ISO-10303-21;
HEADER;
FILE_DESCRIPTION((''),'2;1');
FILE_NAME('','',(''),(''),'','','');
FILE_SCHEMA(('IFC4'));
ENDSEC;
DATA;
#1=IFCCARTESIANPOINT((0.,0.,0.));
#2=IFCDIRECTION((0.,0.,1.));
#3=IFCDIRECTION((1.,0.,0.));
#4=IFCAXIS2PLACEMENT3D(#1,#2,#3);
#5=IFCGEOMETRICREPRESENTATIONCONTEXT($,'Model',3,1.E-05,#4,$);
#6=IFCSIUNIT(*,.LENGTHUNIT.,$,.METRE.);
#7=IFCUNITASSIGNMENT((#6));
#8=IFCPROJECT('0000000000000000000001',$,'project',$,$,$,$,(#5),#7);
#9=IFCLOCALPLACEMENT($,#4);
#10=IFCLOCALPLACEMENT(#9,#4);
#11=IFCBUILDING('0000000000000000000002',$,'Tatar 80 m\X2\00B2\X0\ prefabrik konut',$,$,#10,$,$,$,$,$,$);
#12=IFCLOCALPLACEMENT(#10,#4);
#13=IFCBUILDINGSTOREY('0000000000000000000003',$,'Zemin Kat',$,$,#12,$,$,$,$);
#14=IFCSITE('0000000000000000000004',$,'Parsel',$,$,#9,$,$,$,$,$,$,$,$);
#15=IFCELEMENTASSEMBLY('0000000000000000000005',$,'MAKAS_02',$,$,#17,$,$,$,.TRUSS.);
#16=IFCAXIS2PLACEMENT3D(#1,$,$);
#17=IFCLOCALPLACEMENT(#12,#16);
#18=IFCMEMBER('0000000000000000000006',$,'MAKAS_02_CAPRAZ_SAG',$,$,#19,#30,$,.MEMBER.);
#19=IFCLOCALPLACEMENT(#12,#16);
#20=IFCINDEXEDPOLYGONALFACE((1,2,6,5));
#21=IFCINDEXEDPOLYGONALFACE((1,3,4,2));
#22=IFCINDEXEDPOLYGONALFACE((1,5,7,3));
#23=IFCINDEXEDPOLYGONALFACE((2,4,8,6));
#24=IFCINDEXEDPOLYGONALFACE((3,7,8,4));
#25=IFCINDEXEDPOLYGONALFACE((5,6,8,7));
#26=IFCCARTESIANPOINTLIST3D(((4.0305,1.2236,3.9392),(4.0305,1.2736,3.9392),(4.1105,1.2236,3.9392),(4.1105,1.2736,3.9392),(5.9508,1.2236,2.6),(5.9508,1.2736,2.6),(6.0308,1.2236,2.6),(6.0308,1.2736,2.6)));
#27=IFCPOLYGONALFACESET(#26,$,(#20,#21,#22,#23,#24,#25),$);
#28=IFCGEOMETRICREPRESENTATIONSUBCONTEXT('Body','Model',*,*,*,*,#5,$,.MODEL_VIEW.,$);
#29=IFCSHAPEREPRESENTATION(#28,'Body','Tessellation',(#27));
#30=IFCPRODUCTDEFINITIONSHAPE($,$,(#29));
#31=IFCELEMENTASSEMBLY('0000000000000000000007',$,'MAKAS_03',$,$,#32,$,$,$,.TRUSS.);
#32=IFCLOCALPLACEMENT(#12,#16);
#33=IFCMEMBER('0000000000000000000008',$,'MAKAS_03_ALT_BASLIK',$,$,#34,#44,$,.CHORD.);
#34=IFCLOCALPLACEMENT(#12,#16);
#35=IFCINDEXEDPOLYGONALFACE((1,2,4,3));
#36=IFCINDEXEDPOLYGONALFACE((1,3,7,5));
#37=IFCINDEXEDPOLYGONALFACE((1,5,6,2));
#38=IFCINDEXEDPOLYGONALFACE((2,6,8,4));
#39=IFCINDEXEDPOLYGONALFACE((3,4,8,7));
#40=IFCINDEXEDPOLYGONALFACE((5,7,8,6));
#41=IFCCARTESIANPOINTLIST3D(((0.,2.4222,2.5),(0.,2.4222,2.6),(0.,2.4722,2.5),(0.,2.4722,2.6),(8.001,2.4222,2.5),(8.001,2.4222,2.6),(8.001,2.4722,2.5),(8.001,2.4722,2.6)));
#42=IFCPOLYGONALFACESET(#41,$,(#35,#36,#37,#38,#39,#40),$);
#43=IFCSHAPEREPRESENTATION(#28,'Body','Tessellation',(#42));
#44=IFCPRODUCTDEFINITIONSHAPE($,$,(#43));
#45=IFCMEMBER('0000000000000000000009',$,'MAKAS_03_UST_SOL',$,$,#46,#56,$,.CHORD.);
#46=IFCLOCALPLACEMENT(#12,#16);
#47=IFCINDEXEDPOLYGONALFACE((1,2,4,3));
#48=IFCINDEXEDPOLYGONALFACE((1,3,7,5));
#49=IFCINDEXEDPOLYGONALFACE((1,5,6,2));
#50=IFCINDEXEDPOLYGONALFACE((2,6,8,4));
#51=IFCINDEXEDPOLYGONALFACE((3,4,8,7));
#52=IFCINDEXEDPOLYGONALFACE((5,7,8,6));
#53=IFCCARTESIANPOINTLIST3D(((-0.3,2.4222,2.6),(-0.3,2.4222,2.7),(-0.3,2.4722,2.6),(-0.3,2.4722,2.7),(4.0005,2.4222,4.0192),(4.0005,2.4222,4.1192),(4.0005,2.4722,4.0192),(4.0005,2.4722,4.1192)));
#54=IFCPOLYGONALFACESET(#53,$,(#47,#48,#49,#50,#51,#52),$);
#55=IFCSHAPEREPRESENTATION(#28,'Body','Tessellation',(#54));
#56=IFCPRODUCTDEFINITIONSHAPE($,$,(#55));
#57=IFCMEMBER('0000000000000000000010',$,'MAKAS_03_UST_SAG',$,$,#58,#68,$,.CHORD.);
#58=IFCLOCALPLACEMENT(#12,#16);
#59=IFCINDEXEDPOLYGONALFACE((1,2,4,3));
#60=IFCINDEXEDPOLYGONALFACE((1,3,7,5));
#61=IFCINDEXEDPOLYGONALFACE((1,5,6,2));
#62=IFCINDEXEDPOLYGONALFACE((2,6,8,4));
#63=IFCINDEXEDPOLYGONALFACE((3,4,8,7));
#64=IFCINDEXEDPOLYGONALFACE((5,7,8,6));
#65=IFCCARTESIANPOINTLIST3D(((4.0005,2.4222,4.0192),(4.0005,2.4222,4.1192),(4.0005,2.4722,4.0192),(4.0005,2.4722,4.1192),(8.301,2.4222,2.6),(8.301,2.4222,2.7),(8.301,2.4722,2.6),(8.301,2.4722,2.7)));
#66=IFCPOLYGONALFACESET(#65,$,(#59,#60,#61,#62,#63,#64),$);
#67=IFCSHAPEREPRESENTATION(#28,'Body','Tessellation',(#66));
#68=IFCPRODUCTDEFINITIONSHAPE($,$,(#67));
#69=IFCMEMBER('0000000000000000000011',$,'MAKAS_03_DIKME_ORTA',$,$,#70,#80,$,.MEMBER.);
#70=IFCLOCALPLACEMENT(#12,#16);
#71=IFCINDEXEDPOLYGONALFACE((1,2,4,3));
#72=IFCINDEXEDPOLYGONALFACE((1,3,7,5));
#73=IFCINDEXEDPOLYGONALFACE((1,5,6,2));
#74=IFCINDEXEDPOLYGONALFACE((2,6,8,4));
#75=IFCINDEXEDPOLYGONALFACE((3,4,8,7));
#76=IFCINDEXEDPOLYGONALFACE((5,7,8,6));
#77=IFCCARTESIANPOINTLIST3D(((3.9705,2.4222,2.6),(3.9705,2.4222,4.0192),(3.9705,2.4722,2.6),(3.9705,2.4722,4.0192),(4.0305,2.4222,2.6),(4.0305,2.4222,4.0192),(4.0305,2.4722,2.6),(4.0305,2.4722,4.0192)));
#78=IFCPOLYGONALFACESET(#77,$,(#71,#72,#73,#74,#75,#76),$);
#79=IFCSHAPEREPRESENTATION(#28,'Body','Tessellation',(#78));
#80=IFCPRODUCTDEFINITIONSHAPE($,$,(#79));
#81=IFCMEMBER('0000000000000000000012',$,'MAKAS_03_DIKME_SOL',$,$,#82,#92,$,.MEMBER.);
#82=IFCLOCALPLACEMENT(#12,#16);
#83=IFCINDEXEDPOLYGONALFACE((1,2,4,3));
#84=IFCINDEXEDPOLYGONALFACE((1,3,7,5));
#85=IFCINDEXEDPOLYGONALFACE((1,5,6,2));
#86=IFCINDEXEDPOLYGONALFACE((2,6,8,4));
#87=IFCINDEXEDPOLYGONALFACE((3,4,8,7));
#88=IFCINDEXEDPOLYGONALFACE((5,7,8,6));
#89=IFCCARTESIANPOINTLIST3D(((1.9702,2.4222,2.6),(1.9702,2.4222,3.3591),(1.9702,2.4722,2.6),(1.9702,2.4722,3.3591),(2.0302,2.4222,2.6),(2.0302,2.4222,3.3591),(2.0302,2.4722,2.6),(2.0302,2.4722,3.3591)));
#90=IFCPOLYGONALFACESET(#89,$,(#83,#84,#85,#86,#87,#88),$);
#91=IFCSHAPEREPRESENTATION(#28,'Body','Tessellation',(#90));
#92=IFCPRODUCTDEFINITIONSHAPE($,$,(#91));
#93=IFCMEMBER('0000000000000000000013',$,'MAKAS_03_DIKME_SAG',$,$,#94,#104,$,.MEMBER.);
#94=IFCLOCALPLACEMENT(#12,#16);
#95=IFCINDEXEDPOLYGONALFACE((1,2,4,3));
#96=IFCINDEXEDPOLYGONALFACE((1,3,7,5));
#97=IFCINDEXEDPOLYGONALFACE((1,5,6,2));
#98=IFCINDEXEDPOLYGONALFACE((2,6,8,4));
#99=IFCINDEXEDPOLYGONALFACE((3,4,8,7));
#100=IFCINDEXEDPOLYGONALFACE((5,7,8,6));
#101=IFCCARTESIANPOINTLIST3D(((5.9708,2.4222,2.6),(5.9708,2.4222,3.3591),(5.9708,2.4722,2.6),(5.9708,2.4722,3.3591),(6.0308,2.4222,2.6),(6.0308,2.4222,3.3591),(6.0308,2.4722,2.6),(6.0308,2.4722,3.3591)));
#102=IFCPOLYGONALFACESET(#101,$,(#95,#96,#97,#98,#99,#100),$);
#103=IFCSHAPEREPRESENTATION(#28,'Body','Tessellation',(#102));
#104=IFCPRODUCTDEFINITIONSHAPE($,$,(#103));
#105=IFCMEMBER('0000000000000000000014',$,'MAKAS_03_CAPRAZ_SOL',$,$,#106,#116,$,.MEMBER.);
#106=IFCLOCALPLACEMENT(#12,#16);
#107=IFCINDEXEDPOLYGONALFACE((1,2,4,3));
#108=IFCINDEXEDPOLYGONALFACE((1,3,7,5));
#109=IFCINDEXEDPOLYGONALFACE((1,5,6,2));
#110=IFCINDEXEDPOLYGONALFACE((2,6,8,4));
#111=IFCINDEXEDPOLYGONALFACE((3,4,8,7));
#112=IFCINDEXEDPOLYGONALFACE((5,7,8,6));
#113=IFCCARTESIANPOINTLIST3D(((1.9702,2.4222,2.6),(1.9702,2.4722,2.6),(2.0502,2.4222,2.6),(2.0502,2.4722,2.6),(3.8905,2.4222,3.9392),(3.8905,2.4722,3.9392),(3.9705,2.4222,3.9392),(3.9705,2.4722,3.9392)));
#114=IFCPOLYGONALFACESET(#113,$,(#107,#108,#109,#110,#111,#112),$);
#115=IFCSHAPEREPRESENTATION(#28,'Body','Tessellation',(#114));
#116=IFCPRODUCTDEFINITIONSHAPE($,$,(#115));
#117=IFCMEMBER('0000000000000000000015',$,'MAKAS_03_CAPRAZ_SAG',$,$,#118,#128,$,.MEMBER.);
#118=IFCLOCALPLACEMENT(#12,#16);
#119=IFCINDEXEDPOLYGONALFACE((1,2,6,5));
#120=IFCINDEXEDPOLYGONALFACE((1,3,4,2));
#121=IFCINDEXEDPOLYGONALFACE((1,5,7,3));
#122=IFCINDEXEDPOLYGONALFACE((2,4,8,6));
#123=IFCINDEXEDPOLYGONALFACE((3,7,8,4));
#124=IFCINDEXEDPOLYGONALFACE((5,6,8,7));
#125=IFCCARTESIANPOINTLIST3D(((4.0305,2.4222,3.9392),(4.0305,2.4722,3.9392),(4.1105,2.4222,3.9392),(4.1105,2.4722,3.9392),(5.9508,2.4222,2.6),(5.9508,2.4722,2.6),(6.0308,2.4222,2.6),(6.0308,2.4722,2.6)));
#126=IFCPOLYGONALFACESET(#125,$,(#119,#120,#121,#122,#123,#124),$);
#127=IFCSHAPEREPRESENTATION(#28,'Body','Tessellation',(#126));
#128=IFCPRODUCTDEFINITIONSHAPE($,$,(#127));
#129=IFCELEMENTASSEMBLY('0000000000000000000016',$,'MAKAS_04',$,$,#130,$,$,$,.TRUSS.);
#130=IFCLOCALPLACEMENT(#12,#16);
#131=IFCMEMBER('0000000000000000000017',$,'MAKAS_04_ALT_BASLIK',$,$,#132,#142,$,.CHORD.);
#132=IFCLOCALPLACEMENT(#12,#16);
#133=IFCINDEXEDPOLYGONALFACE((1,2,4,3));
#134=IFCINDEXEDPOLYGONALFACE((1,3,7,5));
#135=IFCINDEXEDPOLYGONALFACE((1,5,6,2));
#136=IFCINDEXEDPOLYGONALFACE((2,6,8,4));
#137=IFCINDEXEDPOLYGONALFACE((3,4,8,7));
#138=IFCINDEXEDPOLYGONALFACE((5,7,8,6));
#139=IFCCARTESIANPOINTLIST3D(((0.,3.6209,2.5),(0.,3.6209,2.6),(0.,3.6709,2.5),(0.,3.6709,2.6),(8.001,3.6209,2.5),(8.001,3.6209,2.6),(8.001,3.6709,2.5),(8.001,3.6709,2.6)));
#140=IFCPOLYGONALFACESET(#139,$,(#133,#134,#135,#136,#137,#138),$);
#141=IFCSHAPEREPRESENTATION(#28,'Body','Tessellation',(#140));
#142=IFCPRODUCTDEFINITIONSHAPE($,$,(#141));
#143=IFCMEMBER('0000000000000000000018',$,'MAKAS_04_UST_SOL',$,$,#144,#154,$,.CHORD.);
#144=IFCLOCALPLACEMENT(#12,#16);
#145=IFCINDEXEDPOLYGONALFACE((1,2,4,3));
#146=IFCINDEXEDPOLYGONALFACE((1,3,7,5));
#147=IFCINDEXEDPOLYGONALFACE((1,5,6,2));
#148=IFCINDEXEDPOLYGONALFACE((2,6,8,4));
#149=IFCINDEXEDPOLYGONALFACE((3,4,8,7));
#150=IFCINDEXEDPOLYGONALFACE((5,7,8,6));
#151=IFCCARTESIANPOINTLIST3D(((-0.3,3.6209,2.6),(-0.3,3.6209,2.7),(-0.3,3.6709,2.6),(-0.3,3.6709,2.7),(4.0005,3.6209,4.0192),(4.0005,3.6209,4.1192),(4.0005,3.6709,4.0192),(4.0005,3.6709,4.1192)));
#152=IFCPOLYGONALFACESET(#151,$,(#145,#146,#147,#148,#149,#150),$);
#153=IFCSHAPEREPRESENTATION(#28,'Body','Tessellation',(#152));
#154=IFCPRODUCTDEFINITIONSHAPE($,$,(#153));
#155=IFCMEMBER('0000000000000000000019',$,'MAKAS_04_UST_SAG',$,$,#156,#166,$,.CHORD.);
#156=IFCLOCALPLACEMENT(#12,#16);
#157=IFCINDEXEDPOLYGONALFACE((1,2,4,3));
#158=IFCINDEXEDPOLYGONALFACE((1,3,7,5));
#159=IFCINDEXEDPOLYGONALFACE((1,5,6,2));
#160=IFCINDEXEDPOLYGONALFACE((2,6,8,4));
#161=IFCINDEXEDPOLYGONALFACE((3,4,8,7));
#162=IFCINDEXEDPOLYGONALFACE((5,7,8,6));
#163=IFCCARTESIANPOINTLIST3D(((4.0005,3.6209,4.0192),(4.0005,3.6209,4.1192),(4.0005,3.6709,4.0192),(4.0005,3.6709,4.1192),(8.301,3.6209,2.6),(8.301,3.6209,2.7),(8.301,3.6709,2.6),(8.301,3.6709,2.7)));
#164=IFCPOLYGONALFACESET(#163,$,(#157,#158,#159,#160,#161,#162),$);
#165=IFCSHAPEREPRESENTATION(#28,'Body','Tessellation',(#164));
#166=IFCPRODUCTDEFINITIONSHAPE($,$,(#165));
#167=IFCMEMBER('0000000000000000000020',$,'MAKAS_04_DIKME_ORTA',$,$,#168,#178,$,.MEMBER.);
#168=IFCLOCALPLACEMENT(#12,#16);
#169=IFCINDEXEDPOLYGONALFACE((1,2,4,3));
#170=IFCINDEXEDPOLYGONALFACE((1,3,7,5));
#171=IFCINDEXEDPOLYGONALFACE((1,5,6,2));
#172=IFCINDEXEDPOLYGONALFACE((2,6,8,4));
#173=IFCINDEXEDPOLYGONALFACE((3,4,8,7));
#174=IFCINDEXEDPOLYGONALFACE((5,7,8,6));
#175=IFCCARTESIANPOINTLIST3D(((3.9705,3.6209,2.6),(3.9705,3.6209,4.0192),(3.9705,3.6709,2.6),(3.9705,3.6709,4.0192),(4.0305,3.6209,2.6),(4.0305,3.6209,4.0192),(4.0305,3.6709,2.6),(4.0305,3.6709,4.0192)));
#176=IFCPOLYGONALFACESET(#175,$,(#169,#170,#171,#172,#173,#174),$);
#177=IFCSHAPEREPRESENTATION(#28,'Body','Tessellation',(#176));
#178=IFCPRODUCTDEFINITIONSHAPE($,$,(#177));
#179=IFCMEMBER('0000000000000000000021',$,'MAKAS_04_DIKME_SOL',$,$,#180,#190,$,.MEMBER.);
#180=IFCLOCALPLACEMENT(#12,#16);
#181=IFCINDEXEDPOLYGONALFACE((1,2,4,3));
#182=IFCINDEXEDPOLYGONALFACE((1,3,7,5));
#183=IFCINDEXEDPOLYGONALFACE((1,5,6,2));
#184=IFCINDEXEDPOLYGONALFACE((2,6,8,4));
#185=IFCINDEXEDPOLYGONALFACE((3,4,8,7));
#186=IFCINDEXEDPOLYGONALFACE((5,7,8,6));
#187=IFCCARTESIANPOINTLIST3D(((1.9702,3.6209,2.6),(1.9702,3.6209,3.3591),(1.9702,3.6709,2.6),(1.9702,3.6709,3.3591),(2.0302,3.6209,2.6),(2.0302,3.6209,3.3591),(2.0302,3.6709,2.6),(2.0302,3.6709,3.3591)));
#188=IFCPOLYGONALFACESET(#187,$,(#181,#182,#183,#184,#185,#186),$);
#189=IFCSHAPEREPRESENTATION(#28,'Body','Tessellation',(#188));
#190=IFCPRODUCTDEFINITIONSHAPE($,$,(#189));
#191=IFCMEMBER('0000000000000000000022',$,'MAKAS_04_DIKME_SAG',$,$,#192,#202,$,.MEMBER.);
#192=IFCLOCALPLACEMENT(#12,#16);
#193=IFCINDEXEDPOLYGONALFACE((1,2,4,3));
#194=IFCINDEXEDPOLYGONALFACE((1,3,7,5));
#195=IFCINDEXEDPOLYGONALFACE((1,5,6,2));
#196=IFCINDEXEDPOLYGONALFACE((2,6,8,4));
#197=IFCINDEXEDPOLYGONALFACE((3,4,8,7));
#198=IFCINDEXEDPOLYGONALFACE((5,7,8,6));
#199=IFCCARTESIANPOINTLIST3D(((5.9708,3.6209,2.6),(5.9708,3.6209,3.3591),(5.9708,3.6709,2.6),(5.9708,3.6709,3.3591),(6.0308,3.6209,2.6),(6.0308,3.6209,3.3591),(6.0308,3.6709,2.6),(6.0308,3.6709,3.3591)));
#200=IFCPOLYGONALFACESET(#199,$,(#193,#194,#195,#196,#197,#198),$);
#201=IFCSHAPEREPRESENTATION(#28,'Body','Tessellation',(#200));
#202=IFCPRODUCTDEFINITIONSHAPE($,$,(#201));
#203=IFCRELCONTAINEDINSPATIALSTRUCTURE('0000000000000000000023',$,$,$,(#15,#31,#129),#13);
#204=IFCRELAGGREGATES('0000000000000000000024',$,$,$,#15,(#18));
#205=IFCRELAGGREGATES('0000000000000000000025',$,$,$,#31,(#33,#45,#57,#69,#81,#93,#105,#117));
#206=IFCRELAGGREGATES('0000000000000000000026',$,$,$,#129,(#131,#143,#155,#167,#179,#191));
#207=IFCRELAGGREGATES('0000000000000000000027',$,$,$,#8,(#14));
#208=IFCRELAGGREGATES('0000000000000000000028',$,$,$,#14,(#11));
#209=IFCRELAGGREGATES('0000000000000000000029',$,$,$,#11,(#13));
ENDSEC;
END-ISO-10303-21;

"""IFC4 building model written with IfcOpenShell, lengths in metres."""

from ifc_helpers import new_model, si_unit, frame, origin_with_axes, place, context, subcontext, project, spatial, line, indexed_curve, outline, extrude, element, aggregate, save


model = new_model("IFC4")

# Units and contexts
model_context = context("Model", 3, precision=1e-05, world=origin_with_axes())
body_context = subcontext(model_context, "Body", "Model", "MODEL_VIEW")
ifc_project = project(units=[si_unit("LENGTHUNIT", "METRE")], contexts=[model_context])

# Site, building, storey
site_placement = place(None, origin_with_axes())
site = spatial("IfcSite", under=ifc_project, at=site_placement, Name="Parsel")
building_placement = place(site_placement, origin_with_axes())
building = spatial("IfcBuilding", under=site, at=building_placement, Name="Tatar 80 m² prefabrik konut")
storey_placement = place(building_placement, origin_with_axes())
storey = spatial("IfcBuildingStorey", under=building, at=storey_placement, Name="Zemin Kat")

# Element assemblies, members
assembly_1_placement = place(storey_placement, origin_with_axes())
assembly_1 = element("IfcElementAssembly", 1, at=assembly_1_placement, inside=storey, Name="MAKAS_02", PredefinedType="TRUSS")
member_1_placement = place(assembly_1_placement, origin_with_axes())
member_1 = element("IfcMember", 2, at=member_1_placement, Name="MAKAS_02_CAPRAZ_SAG", PredefinedType="MEMBER", context=body_context, shape_type="SweptSolid", body=[
    extrude(outline(indexed_curve([(5.9508, 2.6), (6.0308, 2.6), (4.1105, 3.9392), (4.0305, 3.9392)], segments=[line(1, 2, 3, 4, 1)])), frame((0.0, 1.2736, 0.0), z_axis=(0.0, -1.0, 0.0), x_axis=(1.0, 0.0, 0.0)), (0.0, 0.0, 1.0), 0.05),
])
aggregate(assembly_1, [member_1])
assembly_2_placement = place(storey_placement, origin_with_axes())
assembly_2 = element("IfcElementAssembly", 3, at=assembly_2_placement, inside=storey, Name="MAKAS_03", PredefinedType="TRUSS")
member_2_placement = place(assembly_2_placement, origin_with_axes())
member_2 = element("IfcMember", 4, at=member_2_placement, Name="MAKAS_03_ALT_BASLIK", PredefinedType="CHORD", context=body_context, shape_type="SweptSolid", body=[
    extrude(outline(indexed_curve([(0.0, 2.5), (8.001, 2.5), (8.001, 2.6), (0.0, 2.6)], segments=[line(1, 2, 3, 4, 1)])), frame((0.0, 2.4722, 0.0), z_axis=(0.0, -1.0, 0.0), x_axis=(1.0, 0.0, 0.0)), (0.0, 0.0, 1.0), 0.05),
])
member_3_placement = place(assembly_2_placement, origin_with_axes())
member_3 = element("IfcMember", 5, at=member_3_placement, Name="MAKAS_03_UST_SOL", PredefinedType="CHORD", context=body_context, shape_type="SweptSolid", body=[
    extrude(outline(indexed_curve([(-0.3, 2.6), (4.0005, 4.0192), (4.0005, 4.1192), (-0.3, 2.7)], segments=[line(1, 2, 3, 4, 1)])), frame((0.0, 2.4722, 0.0), z_axis=(0.0, -1.0, 0.0), x_axis=(1.0, 0.0, 0.0)), (0.0, 0.0, 1.0), 0.05),
])
member_4_placement = place(assembly_2_placement, origin_with_axes())
member_4 = element("IfcMember", 6, at=member_4_placement, Name="MAKAS_03_UST_SAG", PredefinedType="CHORD", context=body_context, shape_type="SweptSolid", body=[
    extrude(outline(indexed_curve([(4.0005, 4.0192), (8.301, 2.6), (8.301, 2.7), (4.0005, 4.1192)], segments=[line(1, 2, 3, 4, 1)])), frame((0.0, 2.4722, 0.0), z_axis=(0.0, -1.0, 0.0), x_axis=(1.0, 0.0, 0.0)), (0.0, 0.0, 1.0), 0.05),
])
member_5_placement = place(assembly_2_placement, origin_with_axes())
member_5 = element("IfcMember", 7, at=member_5_placement, Name="MAKAS_03_DIKME_ORTA", PredefinedType="MEMBER", context=body_context, shape_type="SweptSolid", body=[
    extrude(outline(indexed_curve([(3.9705, 2.6), (4.0305, 2.6), (4.0305, 4.0192), (3.9705, 4.0192)], segments=[line(1, 2, 3, 4, 1)])), frame((0.0, 2.4722, 0.0), z_axis=(0.0, -1.0, 0.0), x_axis=(1.0, 0.0, 0.0)), (0.0, 0.0, 1.0), 0.05),
])
member_6_placement = place(assembly_2_placement, origin_with_axes())
member_6 = element("IfcMember", 8, at=member_6_placement, Name="MAKAS_03_DIKME_SOL", PredefinedType="MEMBER", context=body_context, shape_type="SweptSolid", body=[
    extrude(outline(indexed_curve([(1.9703, 2.6), (2.0303, 2.6), (2.0303, 3.3591), (1.9703, 3.3591)], segments=[line(1, 2, 3, 4, 1)])), frame((0.0, 2.4722, 0.0), z_axis=(0.0, -1.0, 0.0), x_axis=(1.0, 0.0, 0.0)), (0.0, 0.0, 1.0), 0.05),
])
member_7_placement = place(assembly_2_placement, origin_with_axes())
member_7 = element("IfcMember", 9, at=member_7_placement, Name="MAKAS_03_DIKME_SAG", PredefinedType="MEMBER", context=body_context, shape_type="SweptSolid", body=[
    extrude(outline(indexed_curve([(5.9708, 2.6), (6.0308, 2.6), (6.0308, 3.3591), (5.9708, 3.3591)], segments=[line(1, 2, 3, 4, 1)])), frame((0.0, 2.4722, 0.0), z_axis=(0.0, -1.0, 0.0), x_axis=(1.0, 0.0, 0.0)), (0.0, 0.0, 1.0), 0.05),
])
member_8_placement = place(assembly_2_placement, origin_with_axes())
member_8 = element("IfcMember", 10, at=member_8_placement, Name="MAKAS_03_CAPRAZ_SOL", PredefinedType="MEMBER", context=body_context, shape_type="SweptSolid", body=[
    extrude(outline(indexed_curve([(1.9703, 2.6), (2.0503, 2.6), (3.9705, 3.9392), (3.8905, 3.9392)], segments=[line(1, 2, 3, 4, 1)])), frame((0.0, 2.4722, 0.0), z_axis=(0.0, -1.0, 0.0), x_axis=(1.0, 0.0, 0.0)), (0.0, 0.0, 1.0), 0.05),
])
member_9_placement = place(assembly_2_placement, origin_with_axes())
member_9 = element("IfcMember", 11, at=member_9_placement, Name="MAKAS_03_CAPRAZ_SAG", PredefinedType="MEMBER", context=body_context, shape_type="SweptSolid", body=[
    extrude(outline(indexed_curve([(5.9508, 2.6), (6.0308, 2.6), (4.1105, 3.9392), (4.0305, 3.9392)], segments=[line(1, 2, 3, 4, 1)])), frame((0.0, 2.4722, 0.0), z_axis=(0.0, -1.0, 0.0), x_axis=(1.0, 0.0, 0.0)), (0.0, 0.0, 1.0), 0.05),
])
aggregate(assembly_2, [member_2, member_3, member_4, member_5, member_6, member_7, member_8, member_9])
assembly_3_placement = place(storey_placement, origin_with_axes())
assembly_3 = element("IfcElementAssembly", 12, at=assembly_3_placement, inside=storey, Name="MAKAS_04", PredefinedType="TRUSS")
member_10_placement = place(assembly_3_placement, origin_with_axes())
member_10 = element("IfcMember", 13, at=member_10_placement, Name="MAKAS_04_ALT_BASLIK", PredefinedType="CHORD", context=body_context, shape_type="SweptSolid", body=[
    extrude(outline(indexed_curve([(0.0, 2.5), (8.001, 2.5), (8.001, 2.6), (0.0, 2.6)], segments=[line(1, 2, 3, 4, 1)])), frame((0.0, 3.6709, 0.0), z_axis=(0.0, -1.0, 0.0), x_axis=(1.0, 0.0, 0.0)), (0.0, 0.0, 1.0), 0.05),
])
member_11_placement = place(assembly_3_placement, origin_with_axes())
member_11 = element("IfcMember", 14, at=member_11_placement, Name="MAKAS_04_UST_SOL", PredefinedType="CHORD", context=body_context, shape_type="SweptSolid", body=[
    extrude(outline(indexed_curve([(-0.3, 2.6), (4.0005, 4.0192), (4.0005, 4.1192), (-0.3, 2.7)], segments=[line(1, 2, 3, 4, 1)])), frame((0.0, 3.6709, 0.0), z_axis=(0.0, -1.0, 0.0), x_axis=(1.0, 0.0, 0.0)), (0.0, 0.0, 1.0), 0.05),
])
member_12_placement = place(assembly_3_placement, origin_with_axes())
member_12 = element("IfcMember", 15, at=member_12_placement, Name="MAKAS_04_UST_SAG", PredefinedType="CHORD", context=body_context, shape_type="SweptSolid", body=[
    extrude(outline(indexed_curve([(4.0005, 4.0192), (8.301, 2.6), (8.301, 2.7), (4.0005, 4.1192)], segments=[line(1, 2, 3, 4, 1)])), frame((0.0, 3.6709, 0.0), z_axis=(0.0, -1.0, 0.0), x_axis=(1.0, 0.0, 0.0)), (0.0, 0.0, 1.0), 0.05),
])
member_13_placement = place(assembly_3_placement, origin_with_axes())
member_13 = element("IfcMember", 16, at=member_13_placement, Name="MAKAS_04_DIKME_ORTA", PredefinedType="MEMBER", context=body_context, shape_type="SweptSolid", body=[
    extrude(outline(indexed_curve([(3.9705, 2.6), (4.0305, 2.6), (4.0305, 4.0192), (3.9705, 4.0192)], segments=[line(1, 2, 3, 4, 1)])), frame((0.0, 3.6709, 0.0), z_axis=(0.0, -1.0, 0.0), x_axis=(1.0, 0.0, 0.0)), (0.0, 0.0, 1.0), 0.05),
])
member_14_placement = place(assembly_3_placement, origin_with_axes())
member_14 = element("IfcMember", 17, at=member_14_placement, Name="MAKAS_04_DIKME_SOL", PredefinedType="MEMBER", context=body_context, shape_type="SweptSolid", body=[
    extrude(outline(indexed_curve([(1.9703, 2.6), (2.0303, 2.6), (2.0303, 3.3591), (1.9703, 3.3591)], segments=[line(1, 2, 3, 4, 1)])), frame((0.0, 3.6709, 0.0), z_axis=(0.0, -1.0, 0.0), x_axis=(1.0, 0.0, 0.0)), (0.0, 0.0, 1.0), 0.05),
])
member_15_placement = place(assembly_3_placement, origin_with_axes())
member_15 = element("IfcMember", 18, at=member_15_placement, Name="MAKAS_04_DIKME_SAG", PredefinedType="MEMBER", context=body_context, shape_type="SweptSolid", body=[
    extrude(outline(indexed_curve([(5.9708, 2.6), (6.0308, 2.6), (6.0308, 3.3591), (5.9708, 3.3591)], segments=[line(1, 2, 3, 4, 1)])), frame((0.0, 3.6709, 0.0), z_axis=(0.0, -1.0, 0.0), x_axis=(1.0, 0.0, 0.0)), (0.0, 0.0, 1.0), 0.05),
])
aggregate(assembly_3, [member_10, member_11, member_12, member_13, member_14, member_15])

save(model, "model.ifc")
